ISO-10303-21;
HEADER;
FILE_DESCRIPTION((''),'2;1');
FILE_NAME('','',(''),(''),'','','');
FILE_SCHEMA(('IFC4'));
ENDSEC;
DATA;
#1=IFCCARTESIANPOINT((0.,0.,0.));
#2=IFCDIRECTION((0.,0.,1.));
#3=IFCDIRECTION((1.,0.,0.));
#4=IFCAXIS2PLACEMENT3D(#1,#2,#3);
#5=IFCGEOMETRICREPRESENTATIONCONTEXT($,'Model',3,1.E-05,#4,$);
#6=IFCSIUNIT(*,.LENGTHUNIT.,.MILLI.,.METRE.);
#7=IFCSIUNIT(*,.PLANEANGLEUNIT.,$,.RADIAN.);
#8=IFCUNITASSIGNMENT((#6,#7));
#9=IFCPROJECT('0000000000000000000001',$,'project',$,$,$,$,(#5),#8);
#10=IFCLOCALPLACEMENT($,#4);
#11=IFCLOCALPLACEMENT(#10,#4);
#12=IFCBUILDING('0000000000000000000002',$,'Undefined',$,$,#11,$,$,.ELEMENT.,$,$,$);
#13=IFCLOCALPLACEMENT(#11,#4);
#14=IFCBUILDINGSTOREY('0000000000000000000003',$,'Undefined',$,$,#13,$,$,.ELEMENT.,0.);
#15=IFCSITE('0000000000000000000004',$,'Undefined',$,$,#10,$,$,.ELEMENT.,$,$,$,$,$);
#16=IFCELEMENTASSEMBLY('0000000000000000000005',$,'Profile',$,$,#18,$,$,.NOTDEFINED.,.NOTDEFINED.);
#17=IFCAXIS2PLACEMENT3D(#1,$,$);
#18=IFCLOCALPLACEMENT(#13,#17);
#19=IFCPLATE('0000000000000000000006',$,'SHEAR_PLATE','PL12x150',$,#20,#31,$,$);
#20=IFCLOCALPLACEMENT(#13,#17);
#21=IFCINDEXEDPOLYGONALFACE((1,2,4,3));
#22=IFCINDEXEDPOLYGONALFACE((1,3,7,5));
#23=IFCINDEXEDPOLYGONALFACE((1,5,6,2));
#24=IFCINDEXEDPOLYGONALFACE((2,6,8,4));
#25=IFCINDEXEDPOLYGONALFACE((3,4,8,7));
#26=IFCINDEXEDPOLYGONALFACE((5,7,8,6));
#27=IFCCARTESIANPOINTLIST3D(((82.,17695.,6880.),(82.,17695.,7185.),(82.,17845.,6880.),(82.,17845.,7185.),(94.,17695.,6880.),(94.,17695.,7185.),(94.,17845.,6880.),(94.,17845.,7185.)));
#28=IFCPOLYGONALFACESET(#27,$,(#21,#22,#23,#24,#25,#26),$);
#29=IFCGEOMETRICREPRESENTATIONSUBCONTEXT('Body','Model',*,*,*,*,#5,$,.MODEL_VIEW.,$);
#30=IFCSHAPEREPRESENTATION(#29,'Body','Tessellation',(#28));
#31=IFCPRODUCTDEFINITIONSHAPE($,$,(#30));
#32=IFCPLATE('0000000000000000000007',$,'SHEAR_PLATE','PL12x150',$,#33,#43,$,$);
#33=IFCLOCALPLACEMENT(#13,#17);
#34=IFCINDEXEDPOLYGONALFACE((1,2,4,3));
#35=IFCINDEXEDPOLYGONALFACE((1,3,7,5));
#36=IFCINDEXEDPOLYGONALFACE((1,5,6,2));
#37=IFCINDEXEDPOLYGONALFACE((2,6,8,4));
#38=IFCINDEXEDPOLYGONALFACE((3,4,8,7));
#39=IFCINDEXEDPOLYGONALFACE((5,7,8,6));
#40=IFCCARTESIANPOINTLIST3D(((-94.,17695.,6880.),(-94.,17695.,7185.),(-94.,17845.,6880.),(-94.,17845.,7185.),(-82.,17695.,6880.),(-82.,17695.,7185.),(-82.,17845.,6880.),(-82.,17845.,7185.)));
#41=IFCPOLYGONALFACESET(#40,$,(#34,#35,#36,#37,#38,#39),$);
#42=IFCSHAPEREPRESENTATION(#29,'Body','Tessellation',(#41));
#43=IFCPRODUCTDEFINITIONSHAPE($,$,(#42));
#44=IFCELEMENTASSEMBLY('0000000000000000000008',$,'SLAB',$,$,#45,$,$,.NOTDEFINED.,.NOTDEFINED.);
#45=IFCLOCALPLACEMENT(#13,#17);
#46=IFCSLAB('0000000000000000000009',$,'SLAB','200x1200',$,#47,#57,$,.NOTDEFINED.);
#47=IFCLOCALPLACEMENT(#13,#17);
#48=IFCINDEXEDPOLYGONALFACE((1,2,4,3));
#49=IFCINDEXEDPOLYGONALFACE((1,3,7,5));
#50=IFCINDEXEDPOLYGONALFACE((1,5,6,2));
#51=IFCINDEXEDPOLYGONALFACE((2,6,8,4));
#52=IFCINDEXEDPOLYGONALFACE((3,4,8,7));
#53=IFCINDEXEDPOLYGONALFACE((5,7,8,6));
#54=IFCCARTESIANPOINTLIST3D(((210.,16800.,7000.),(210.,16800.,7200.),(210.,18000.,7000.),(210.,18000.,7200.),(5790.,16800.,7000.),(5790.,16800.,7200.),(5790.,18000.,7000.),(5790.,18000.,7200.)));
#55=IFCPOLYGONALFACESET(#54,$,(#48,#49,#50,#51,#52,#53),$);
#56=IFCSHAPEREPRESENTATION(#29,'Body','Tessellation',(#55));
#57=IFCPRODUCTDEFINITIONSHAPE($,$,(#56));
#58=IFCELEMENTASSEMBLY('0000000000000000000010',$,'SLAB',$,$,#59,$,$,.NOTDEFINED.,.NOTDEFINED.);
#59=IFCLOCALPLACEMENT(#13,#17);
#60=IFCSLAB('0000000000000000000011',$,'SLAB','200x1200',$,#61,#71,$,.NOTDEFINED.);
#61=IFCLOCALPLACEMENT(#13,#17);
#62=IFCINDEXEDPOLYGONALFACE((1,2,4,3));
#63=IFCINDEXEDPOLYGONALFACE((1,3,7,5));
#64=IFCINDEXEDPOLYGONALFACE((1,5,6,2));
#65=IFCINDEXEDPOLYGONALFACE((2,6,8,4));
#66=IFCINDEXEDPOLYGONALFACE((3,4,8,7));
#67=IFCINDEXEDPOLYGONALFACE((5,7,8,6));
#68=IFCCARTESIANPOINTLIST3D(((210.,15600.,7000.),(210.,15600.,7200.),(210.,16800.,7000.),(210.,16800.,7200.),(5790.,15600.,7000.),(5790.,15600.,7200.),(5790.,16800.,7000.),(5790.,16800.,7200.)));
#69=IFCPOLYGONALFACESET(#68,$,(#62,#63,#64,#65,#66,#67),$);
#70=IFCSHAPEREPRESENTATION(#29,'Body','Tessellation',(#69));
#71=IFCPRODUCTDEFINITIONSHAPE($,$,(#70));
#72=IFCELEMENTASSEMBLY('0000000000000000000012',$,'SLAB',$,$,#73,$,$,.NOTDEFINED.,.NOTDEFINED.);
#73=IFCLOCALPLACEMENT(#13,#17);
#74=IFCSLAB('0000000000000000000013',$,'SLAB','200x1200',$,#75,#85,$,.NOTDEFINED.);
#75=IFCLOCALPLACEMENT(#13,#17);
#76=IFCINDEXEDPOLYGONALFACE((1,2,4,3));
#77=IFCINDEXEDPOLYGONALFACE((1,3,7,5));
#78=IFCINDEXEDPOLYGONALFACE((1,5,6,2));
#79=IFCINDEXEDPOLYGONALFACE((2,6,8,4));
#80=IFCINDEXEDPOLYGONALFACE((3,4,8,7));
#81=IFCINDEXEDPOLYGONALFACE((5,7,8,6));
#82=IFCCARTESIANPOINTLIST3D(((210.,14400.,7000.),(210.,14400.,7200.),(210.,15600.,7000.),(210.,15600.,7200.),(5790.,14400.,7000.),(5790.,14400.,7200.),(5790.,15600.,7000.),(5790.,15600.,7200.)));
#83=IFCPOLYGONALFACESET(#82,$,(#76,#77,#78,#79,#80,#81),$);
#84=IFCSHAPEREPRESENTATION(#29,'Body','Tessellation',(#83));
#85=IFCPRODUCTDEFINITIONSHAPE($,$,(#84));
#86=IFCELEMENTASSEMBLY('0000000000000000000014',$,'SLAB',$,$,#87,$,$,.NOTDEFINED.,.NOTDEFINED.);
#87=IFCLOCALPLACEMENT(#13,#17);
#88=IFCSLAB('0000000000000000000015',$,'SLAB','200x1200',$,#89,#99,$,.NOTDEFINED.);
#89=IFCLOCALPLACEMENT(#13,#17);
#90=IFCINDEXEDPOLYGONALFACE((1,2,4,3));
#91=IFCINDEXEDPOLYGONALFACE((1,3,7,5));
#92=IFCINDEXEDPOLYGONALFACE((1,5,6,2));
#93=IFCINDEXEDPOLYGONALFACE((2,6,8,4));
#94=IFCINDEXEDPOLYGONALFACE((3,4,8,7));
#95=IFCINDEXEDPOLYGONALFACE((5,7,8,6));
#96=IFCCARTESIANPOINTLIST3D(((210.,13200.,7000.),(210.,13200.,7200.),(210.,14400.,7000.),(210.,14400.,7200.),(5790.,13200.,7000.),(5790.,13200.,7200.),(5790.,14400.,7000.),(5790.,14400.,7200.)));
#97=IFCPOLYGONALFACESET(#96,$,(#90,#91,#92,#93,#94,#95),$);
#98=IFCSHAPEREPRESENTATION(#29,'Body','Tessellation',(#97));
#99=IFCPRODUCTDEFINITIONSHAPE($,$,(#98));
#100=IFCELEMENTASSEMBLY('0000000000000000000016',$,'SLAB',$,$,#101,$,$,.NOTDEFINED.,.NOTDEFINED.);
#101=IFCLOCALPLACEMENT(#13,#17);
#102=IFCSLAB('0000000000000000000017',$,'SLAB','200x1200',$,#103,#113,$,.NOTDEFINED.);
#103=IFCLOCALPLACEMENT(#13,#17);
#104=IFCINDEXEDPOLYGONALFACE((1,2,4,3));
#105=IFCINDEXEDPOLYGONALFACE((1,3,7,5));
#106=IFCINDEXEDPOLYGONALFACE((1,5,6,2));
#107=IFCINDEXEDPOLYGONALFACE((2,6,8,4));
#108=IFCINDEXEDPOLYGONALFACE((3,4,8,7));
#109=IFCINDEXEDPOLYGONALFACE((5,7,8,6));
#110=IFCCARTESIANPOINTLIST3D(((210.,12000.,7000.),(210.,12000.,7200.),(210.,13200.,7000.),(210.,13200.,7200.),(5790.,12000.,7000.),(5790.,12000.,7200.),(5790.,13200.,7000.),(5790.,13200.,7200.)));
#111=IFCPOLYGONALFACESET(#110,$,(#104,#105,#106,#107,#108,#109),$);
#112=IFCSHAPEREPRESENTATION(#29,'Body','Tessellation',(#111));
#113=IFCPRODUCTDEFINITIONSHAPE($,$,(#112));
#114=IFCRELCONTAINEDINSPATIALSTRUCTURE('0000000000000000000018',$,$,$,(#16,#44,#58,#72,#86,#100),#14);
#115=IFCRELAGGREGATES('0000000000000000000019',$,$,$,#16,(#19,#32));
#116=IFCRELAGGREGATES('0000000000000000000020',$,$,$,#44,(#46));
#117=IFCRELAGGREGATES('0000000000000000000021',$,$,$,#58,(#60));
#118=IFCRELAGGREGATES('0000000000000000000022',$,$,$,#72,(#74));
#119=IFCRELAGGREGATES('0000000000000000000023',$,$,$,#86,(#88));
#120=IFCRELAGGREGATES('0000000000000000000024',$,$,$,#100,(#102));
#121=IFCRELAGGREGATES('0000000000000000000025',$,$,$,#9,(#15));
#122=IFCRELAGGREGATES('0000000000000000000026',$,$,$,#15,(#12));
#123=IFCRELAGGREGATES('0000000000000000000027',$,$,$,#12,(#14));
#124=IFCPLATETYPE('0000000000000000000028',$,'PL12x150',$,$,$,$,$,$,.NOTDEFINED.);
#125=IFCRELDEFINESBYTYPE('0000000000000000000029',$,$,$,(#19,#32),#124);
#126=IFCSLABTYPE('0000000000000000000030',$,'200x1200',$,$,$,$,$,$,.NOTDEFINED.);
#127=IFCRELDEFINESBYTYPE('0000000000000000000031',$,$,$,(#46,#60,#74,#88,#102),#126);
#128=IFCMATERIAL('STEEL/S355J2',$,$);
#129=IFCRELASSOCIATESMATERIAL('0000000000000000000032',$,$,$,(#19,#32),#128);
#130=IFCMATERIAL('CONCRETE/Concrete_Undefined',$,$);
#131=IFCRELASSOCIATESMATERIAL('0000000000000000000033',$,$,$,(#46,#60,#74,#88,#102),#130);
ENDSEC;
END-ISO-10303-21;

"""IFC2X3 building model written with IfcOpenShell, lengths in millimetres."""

from ifc_helpers import new_model, si_unit, frame, origin_with_axes, place, context, subcontext, project, spatial, polyline, outline, extrude, material, type_object, element, aggregate, save


model = new_model("IFC2X3")

# Units and contexts
model_context = context("Model", 3, precision=1e-05, world=origin_with_axes())
body_context = subcontext(model_context, "Body", "Model", "MODEL_VIEW")
ifc_project = project(units=[si_unit("LENGTHUNIT", "METRE", prefix="MILLI"), si_unit("PLANEANGLEUNIT", "RADIAN")], contexts=[model_context])

# Site, building, storey
site_placement = place(None, origin_with_axes())
site = spatial("IfcSite", under=ifc_project, at=site_placement, Name="Undefined", CompositionType="ELEMENT")
building_placement = place(site_placement, origin_with_axes())
building = spatial("IfcBuilding", under=site, at=building_placement, Name="Undefined", CompositionType="ELEMENT")
storey_placement = place(building_placement, origin_with_axes())
storey = spatial("IfcBuildingStorey", under=building, at=storey_placement, Name="Undefined", CompositionType="ELEMENT", Elevation=0.0)

# Element assembly
ifc_material_1 = material(Name="STEEL/S355J2")
assembly_1_placement = place(storey_placement, origin_with_axes())
assembly_1 = element("IfcElementAssembly", 1, at=assembly_1_placement, inside=storey, Name="Profile", AssemblyPlace="NOTDEFINED", PredefinedType="NOTDEFINED")

# Plates
plate_type_1 = type_object("IfcPlateType", Name="PL12x150", PredefinedType="NOTDEFINED")
plate_1_placement = place(assembly_1_placement, frame((88.0, 17845.0, 7185.0), z_axis=(1.0, 0.0, 0.0), x_axis=(0.0, -1.0, 0.0)))
plate_1 = element("IfcPlate", 2, at=plate_1_placement, type_object=plate_type_1, material=ifc_material_1, Name="SHEAR_PLATE", Description="PL12x150", context=body_context, shape_type="SweptSolid", body=[
    extrude(outline(polyline([(0.0, 0.0), (150.0, 0.0), (150.0, 0.0), (150.0, 305.0), (150.0, 305.0), (0.0, 305.0), (0.0, 305.0), (0.0, 0.0)])), frame((0.0, 0.0, -6.0), z_axis=(0.0, 0.0, 1.0), x_axis=(1.0, 0.0, 0.0)), (0.0, 0.0, 1.0), 12.0),
])
plate_2_placement = place(assembly_1_placement, frame((-88.0, 17845.0, 7185.0), z_axis=(1.0, 0.0, 0.0), x_axis=(0.0, -1.0, 0.0)))
plate_2 = element("IfcPlate", 3, at=plate_2_placement, type_object=plate_type_1, material=ifc_material_1, Name="SHEAR_PLATE", Description="PL12x150", context=body_context, shape_type="SweptSolid", body=[
    extrude(outline(polyline([(0.0, 0.0), (150.0, 0.0), (150.0, 0.0), (150.0, 305.0), (150.0, 305.0), (0.0, 305.0), (0.0, 305.0), (0.0, 0.0)])), frame((0.0, 0.0, -6.0), z_axis=(0.0, 0.0, 1.0), x_axis=(1.0, 0.0, 0.0)), (0.0, 0.0, 1.0), 12.0),
])
aggregate(assembly_1, [plate_1, plate_2])

# Element assemblies, slabs
assembly_2_placement = place(storey_placement, origin_with_axes())
assembly_2 = element("IfcElementAssembly", 4, at=assembly_2_placement, inside=storey, Name="SLAB", AssemblyPlace="NOTDEFINED", PredefinedType="NOTDEFINED")
ifc_material_2 = material(Name="CONCRETE/Concrete_Undefined")
slab_type = type_object("IfcSlabType", Name="200x1200", PredefinedType="NOTDEFINED")
slab_1_placement = place(assembly_2_placement, frame((5790.0, 16800.0, 7100.0), z_axis=(0.0, 0.0, 1.0), x_axis=(0.0, 1.0, 0.0)))
slab_1 = element("IfcSlab", 5, at=slab_1_placement, type_object=slab_type, material=ifc_material_2, Name="SLAB", Description="200x1200", PredefinedType="NOTDEFINED", context=body_context, shape_type="SweptSolid", body=[
    extrude(outline(polyline([(0.0, 0.0), (1200.0, 0.0), (1200.0, 5580.0), (0.0, 5580.0), (0.0, 0.0)])), frame((0.0, 0.0, -100.0), z_axis=(0.0, 0.0, 1.0), x_axis=(1.0, 0.0, 0.0)), (0.0, 0.0, 1.0), 200.0),
])
aggregate(assembly_2, [slab_1])
assembly_3_placement = place(storey_placement, origin_with_axes())
assembly_3 = element("IfcElementAssembly", 6, at=assembly_3_placement, inside=storey, Name="SLAB", AssemblyPlace="NOTDEFINED", PredefinedType="NOTDEFINED")
slab_2_placement = place(assembly_3_placement, frame((5790.0, 15600.0, 7100.0), z_axis=(0.0, 0.0, 1.0), x_axis=(0.0, 1.0, 0.0)))
slab_2 = element("IfcSlab", 7, at=slab_2_placement, type_object=slab_type, material=ifc_material_2, Name="SLAB", Description="200x1200", PredefinedType="NOTDEFINED", context=body_context, shape_type="SweptSolid", body=[
    extrude(outline(polyline([(0.0, 0.0), (1200.0, 0.0), (1200.0, 5580.0), (0.0, 5580.0), (0.0, 0.0)])), frame((0.0, 0.0, -100.0), z_axis=(0.0, 0.0, 1.0), x_axis=(1.0, 0.0, 0.0)), (0.0, 0.0, 1.0), 200.0),
])
aggregate(assembly_3, [slab_2])
assembly_4_placement = place(storey_placement, origin_with_axes())
assembly_4 = element("IfcElementAssembly", 8, at=assembly_4_placement, inside=storey, Name="SLAB", AssemblyPlace="NOTDEFINED", PredefinedType="NOTDEFINED")
slab_3_placement = place(assembly_4_placement, frame((5790.0, 14400.0, 7100.0), z_axis=(0.0, 0.0, 1.0), x_axis=(0.0, 1.0, 0.0)))
slab_3 = element("IfcSlab", 9, at=slab_3_placement, type_object=slab_type, material=ifc_material_2, Name="SLAB", Description="200x1200", PredefinedType="NOTDEFINED", context=body_context, shape_type="SweptSolid", body=[
    extrude(outline(polyline([(0.0, 0.0), (1200.0, 0.0), (1200.0, 5580.0), (0.0, 5580.0), (0.0, 0.0)])), frame((0.0, 0.0, -100.0), z_axis=(0.0, 0.0, 1.0), x_axis=(1.0, 0.0, 0.0)), (0.0, 0.0, 1.0), 200.0),
])
aggregate(assembly_4, [slab_3])
assembly_5_placement = place(storey_placement, origin_with_axes())
assembly_5 = element("IfcElementAssembly", 10, at=assembly_5_placement, inside=storey, Name="SLAB", AssemblyPlace="NOTDEFINED", PredefinedType="NOTDEFINED")
slab_4_placement = place(assembly_5_placement, frame((5790.0, 13200.0, 7100.0), z_axis=(0.0, 0.0, 1.0), x_axis=(0.0, 1.0, 0.0)))
slab_4 = element("IfcSlab", 11, at=slab_4_placement, type_object=slab_type, material=ifc_material_2, Name="SLAB", Description="200x1200", PredefinedType="NOTDEFINED", context=body_context, shape_type="SweptSolid", body=[
    extrude(outline(polyline([(0.0, 0.0), (1200.0, 0.0), (1200.0, 5580.0), (0.0, 5580.0), (0.0, 0.0)])), frame((0.0, 0.0, -100.0), z_axis=(0.0, 0.0, 1.0), x_axis=(1.0, 0.0, 0.0)), (0.0, 0.0, 1.0), 200.0),
])
aggregate(assembly_5, [slab_4])
assembly_6_placement = place(storey_placement, origin_with_axes())
assembly_6 = element("IfcElementAssembly", 12, at=assembly_6_placement, inside=storey, Name="SLAB", AssemblyPlace="NOTDEFINED", PredefinedType="NOTDEFINED")
slab_5_placement = place(assembly_6_placement, frame((5790.0, 12000.0, 7100.0), z_axis=(0.0, 0.0, 1.0), x_axis=(0.0, 1.0, 0.0)))
slab_5 = element("IfcSlab", 13, at=slab_5_placement, type_object=slab_type, material=ifc_material_2, Name="SLAB", Description="200x1200", PredefinedType="NOTDEFINED", context=body_context, shape_type="SweptSolid", body=[
    extrude(outline(polyline([(0.0, 0.0), (1200.0, 0.0), (1200.0, 5580.0), (0.0, 5580.0), (0.0, 0.0)])), frame((0.0, 0.0, -100.0), z_axis=(0.0, 0.0, 1.0), x_axis=(1.0, 0.0, 0.0)), (0.0, 0.0, 1.0), 200.0),
])
aggregate(assembly_6, [slab_5])

save(model, "model.ifc")
